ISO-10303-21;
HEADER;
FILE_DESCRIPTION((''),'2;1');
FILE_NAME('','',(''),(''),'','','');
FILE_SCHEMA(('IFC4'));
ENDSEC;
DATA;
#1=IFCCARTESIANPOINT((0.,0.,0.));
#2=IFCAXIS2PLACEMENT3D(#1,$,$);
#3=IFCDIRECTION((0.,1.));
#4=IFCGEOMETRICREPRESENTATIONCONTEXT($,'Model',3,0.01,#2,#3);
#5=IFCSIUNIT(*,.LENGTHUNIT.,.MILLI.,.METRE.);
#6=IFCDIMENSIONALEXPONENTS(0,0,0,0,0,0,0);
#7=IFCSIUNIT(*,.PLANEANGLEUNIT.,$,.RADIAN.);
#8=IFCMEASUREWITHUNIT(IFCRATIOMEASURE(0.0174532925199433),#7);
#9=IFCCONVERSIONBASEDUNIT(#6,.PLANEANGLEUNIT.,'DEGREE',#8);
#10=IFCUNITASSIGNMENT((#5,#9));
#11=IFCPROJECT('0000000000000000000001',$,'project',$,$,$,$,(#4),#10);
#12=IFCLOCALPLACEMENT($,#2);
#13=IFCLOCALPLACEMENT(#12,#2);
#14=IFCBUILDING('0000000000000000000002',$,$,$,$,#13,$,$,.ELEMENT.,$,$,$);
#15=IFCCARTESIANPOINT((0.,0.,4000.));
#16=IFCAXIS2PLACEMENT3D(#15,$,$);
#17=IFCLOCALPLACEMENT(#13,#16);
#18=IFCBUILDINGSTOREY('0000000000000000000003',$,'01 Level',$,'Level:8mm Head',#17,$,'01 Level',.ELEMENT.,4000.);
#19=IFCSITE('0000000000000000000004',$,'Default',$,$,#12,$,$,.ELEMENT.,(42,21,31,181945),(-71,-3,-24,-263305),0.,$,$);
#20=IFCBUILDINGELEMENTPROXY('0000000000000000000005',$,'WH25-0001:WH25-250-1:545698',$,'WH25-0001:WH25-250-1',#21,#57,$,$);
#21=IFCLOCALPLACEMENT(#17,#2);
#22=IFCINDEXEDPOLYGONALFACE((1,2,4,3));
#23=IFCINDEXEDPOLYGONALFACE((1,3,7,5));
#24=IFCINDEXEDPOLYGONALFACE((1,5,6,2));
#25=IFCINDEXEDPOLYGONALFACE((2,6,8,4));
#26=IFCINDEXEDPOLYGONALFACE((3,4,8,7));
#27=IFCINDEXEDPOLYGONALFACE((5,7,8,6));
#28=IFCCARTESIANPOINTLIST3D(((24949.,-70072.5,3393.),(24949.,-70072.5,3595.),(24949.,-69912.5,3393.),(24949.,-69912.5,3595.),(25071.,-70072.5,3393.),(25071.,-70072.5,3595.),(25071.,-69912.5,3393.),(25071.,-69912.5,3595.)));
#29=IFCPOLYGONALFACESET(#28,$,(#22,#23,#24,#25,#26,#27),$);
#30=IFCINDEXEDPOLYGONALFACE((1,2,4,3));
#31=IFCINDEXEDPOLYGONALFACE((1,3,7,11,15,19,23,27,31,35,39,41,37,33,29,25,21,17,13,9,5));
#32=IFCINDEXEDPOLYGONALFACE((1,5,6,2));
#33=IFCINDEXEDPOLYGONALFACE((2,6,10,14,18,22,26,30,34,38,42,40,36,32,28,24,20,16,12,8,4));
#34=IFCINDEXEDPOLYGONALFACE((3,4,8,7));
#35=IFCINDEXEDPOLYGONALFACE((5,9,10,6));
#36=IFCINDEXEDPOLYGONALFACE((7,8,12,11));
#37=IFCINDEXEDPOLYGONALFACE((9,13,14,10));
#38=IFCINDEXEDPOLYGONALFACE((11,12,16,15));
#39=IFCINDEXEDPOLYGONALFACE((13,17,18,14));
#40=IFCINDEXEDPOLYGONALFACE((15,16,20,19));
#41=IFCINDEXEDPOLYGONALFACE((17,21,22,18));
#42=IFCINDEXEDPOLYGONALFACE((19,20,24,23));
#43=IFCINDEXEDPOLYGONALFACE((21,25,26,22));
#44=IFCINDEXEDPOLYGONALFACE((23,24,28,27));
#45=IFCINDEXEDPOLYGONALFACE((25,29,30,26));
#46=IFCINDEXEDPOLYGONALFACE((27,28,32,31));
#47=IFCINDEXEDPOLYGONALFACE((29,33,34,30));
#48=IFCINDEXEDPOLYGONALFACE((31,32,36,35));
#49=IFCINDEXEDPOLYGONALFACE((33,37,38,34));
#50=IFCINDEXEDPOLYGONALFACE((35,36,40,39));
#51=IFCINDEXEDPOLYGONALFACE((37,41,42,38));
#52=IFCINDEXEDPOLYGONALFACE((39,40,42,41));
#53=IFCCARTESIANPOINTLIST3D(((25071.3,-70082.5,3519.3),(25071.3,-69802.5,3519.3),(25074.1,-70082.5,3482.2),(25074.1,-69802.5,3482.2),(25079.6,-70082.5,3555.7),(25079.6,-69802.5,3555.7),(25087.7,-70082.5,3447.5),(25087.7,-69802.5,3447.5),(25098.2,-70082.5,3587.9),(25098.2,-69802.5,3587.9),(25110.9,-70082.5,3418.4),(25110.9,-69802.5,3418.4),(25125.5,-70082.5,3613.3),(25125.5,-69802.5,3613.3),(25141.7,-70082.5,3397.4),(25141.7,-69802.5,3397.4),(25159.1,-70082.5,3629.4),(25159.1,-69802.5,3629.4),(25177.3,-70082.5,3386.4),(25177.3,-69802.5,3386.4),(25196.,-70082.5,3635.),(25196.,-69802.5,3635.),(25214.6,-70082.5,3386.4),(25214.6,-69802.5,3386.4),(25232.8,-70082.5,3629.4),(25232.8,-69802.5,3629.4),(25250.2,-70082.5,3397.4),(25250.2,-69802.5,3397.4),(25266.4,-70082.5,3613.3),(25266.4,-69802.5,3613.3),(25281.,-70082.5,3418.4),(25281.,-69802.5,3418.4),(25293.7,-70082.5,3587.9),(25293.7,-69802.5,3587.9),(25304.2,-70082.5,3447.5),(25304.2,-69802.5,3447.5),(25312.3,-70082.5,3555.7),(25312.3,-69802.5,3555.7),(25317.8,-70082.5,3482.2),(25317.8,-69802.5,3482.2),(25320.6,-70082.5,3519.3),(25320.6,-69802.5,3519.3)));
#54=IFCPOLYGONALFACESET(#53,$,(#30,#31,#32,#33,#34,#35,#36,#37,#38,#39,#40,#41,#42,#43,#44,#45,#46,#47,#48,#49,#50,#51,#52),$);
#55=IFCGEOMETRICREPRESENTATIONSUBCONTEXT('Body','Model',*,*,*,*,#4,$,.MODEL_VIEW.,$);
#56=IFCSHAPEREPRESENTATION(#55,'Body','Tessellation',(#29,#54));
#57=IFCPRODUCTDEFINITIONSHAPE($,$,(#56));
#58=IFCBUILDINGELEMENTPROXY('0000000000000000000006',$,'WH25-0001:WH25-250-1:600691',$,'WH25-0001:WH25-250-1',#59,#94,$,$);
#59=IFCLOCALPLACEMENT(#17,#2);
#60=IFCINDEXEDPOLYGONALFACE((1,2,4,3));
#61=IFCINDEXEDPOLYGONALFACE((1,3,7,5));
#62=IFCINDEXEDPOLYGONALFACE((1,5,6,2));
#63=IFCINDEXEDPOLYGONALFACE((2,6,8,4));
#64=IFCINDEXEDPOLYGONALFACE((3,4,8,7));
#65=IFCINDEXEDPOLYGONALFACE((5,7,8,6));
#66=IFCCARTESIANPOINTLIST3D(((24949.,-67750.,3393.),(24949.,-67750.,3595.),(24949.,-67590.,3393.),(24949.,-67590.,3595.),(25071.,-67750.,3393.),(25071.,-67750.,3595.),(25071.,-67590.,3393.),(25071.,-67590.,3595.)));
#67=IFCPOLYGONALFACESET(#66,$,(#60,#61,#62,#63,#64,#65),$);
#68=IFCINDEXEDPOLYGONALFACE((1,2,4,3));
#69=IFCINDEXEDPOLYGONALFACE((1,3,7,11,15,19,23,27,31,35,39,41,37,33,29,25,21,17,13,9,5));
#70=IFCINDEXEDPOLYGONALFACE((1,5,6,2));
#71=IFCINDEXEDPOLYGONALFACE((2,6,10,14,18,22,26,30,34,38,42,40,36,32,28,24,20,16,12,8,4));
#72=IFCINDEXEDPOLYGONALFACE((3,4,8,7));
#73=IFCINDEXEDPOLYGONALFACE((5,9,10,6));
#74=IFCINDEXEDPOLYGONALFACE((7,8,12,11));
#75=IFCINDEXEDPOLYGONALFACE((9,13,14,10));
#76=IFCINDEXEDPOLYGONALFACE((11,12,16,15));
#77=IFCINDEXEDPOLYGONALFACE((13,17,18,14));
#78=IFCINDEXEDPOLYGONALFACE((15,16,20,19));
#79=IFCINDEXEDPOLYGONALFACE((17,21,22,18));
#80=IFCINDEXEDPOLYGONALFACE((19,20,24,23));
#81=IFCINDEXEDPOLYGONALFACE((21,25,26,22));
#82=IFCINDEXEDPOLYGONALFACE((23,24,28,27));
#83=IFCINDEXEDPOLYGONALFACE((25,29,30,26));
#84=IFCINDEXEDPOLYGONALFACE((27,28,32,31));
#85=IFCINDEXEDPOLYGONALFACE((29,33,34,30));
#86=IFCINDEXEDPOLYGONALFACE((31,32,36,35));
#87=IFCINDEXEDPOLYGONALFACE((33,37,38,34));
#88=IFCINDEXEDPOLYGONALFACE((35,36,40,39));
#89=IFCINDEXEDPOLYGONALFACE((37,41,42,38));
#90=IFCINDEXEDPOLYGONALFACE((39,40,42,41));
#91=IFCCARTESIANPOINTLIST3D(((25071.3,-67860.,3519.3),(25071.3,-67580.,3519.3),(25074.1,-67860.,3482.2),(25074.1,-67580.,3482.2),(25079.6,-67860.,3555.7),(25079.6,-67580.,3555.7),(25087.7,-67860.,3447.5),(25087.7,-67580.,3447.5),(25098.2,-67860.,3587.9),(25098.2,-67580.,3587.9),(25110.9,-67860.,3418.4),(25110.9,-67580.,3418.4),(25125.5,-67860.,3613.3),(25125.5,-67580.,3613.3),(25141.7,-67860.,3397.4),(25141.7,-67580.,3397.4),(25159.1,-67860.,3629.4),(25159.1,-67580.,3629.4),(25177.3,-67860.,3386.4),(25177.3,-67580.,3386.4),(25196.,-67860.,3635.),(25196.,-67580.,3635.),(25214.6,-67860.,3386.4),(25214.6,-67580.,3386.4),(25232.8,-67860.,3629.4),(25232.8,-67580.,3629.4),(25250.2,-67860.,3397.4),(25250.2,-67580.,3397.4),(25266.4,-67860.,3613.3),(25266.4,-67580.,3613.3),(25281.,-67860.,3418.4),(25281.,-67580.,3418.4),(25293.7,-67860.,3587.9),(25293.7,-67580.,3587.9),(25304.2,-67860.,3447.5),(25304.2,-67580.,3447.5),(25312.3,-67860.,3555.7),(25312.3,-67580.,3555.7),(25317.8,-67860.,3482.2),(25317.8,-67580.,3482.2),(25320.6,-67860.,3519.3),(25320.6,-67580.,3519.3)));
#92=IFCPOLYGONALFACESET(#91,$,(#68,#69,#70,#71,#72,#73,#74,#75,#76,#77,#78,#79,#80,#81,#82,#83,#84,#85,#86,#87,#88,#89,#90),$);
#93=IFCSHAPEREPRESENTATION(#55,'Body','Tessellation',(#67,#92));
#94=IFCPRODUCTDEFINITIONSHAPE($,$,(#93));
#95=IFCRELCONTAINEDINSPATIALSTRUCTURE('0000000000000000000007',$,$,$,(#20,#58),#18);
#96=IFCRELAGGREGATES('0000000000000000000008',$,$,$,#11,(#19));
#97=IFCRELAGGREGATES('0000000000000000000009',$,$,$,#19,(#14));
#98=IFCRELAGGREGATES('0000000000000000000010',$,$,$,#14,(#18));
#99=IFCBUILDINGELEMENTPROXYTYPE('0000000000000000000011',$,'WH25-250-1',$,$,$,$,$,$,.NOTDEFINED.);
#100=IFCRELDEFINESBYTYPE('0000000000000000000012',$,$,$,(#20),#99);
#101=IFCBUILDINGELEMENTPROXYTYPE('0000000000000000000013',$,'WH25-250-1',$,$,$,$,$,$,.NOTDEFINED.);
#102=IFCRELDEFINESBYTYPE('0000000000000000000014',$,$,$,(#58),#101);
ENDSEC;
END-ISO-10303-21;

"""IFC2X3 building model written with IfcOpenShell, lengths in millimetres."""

from ifc_helpers import new_model, entity, si_unit, converted_unit, direction, frame, frame_2d, origin, origin_2d_with_axis, place, context, subcontext, project, spatial, rectangle, circle, extrude, source, transform, mapped, type_object, type_shapes, element, save


model = new_model("IFC2X3")

# Units and contexts
model_context = context("Model", 3, precision=0.01, world=origin(), true_north=direction((0.0, 1.0)))
body_context = subcontext(model_context, "Body", "Model", "MODEL_VIEW")
ifc_project = project(units=[si_unit("LENGTHUNIT", "METRE", prefix="MILLI"), converted_unit("PLANEANGLEUNIT", "DEGREE", entity("IfcRatioMeasure", 0.0174532925199433), si_unit("PLANEANGLEUNIT", "RADIAN"), dimensions=[0, 0, 0, 0, 0, 0, 0])], contexts=[model_context])

# Site, building, storey
site_placement = place(None, origin())
site = spatial("IfcSite", under=ifc_project, at=site_placement, Name="Default", CompositionType="ELEMENT", RefLatitude=(42, 21, 31, 181945), RefLongitude=(-71, -3, -24, -263305), RefElevation=0.0)
building_placement = place(site_placement, origin())
building = spatial("IfcBuilding", under=site, at=building_placement, CompositionType="ELEMENT")
storey_placement = place(building_placement, frame((0.0, 0.0, 4000.0)))
storey = spatial("IfcBuildingStorey", under=building, at=storey_placement, Name="01 Level", ObjectType="Level:8mm Head", LongName="01 Level", CompositionType="ELEMENT", Elevation=4000.0)

# Building element proxies
building_element_proxy_type_1 = type_object("IfcBuildingElementProxyType", Name="WH25-250-1", PredefinedType="NOTDEFINED")
shared_shape_1 = source(origin(), body_context, "Body", "SweptSolid", [
    extrude(rectangle(XDim=202.0, YDim=160.0, at=origin_2d_with_axis()), frame((50.0, -16.0, 125.0), z_axis=(0.0, 0.0, 1.0), x_axis=(0.0, -1.0, 0.0)), (0.0, 0.0, 1.0), 122.0),
    extrude(circle(Radius=125.0, at=frame_2d((0.0, 0.0), x_axis=(1.0, 0.0))), frame((-140.0, 0.0, 0.0), z_axis=(1.0, 0.0, 0.0), x_axis=(0.0, 1.0, 0.0)), (0.0, 0.0, 1.0), 280.0),
])
type_shapes(building_element_proxy_type_1, [shared_shape_1])
proxy_1_placement = place(storey_placement, frame((25196.0, -69942.5, 3510.0), z_axis=(-1.0, 0.0, 0.0), x_axis=(0.0, -1.0, 0.0)))
element("IfcBuildingElementProxy", 1, at=proxy_1_placement, inside=storey, type_object=building_element_proxy_type_1, Name="WH25-0001:WH25-250-1:545698", ObjectType="WH25-0001:WH25-250-1", context=body_context, shape_type="MappedRepresentation", body=[
    mapped(shared_shape_1, transform((0.0, 0.0, 0.0), scale=1.0)),
])
building_element_proxy_type_2 = type_object("IfcBuildingElementProxyType", Name="WH25-250-1", PredefinedType="NOTDEFINED")
shared_shape_2 = source(origin(), body_context, "Body", "SweptSolid", [
    extrude(rectangle(XDim=160.0, YDim=202.0, at=origin_2d_with_axis()), frame((50.0, 16.0, 125.0)), (0.0, 0.0, 1.0), 122.0),
    extrude(circle(Radius=125.0, at=frame_2d((0.0, 0.0), x_axis=(1.0, 0.0))), frame((-140.0, 0.0, 0.0), z_axis=(1.0, 0.0, 0.0), x_axis=(0.0, -1.0, 0.0)), (0.0, 0.0, 1.0), 280.0),
])
type_shapes(building_element_proxy_type_2, [shared_shape_2])
proxy_2_placement = place(storey_placement, frame((25196.0, -67720.0, 3510.0), z_axis=(-1.0, 0.0, 0.0), x_axis=(0.0, 1.0, 0.0)))
element("IfcBuildingElementProxy", 2, at=proxy_2_placement, inside=storey, type_object=building_element_proxy_type_2, Name="WH25-0001:WH25-250-1:600691", ObjectType="WH25-0001:WH25-250-1", context=body_context, shape_type="MappedRepresentation", body=[
    mapped(shared_shape_2, transform((0.0, 0.0, 0.0), scale=1.0)),
])

save(model, "model.ifc")
